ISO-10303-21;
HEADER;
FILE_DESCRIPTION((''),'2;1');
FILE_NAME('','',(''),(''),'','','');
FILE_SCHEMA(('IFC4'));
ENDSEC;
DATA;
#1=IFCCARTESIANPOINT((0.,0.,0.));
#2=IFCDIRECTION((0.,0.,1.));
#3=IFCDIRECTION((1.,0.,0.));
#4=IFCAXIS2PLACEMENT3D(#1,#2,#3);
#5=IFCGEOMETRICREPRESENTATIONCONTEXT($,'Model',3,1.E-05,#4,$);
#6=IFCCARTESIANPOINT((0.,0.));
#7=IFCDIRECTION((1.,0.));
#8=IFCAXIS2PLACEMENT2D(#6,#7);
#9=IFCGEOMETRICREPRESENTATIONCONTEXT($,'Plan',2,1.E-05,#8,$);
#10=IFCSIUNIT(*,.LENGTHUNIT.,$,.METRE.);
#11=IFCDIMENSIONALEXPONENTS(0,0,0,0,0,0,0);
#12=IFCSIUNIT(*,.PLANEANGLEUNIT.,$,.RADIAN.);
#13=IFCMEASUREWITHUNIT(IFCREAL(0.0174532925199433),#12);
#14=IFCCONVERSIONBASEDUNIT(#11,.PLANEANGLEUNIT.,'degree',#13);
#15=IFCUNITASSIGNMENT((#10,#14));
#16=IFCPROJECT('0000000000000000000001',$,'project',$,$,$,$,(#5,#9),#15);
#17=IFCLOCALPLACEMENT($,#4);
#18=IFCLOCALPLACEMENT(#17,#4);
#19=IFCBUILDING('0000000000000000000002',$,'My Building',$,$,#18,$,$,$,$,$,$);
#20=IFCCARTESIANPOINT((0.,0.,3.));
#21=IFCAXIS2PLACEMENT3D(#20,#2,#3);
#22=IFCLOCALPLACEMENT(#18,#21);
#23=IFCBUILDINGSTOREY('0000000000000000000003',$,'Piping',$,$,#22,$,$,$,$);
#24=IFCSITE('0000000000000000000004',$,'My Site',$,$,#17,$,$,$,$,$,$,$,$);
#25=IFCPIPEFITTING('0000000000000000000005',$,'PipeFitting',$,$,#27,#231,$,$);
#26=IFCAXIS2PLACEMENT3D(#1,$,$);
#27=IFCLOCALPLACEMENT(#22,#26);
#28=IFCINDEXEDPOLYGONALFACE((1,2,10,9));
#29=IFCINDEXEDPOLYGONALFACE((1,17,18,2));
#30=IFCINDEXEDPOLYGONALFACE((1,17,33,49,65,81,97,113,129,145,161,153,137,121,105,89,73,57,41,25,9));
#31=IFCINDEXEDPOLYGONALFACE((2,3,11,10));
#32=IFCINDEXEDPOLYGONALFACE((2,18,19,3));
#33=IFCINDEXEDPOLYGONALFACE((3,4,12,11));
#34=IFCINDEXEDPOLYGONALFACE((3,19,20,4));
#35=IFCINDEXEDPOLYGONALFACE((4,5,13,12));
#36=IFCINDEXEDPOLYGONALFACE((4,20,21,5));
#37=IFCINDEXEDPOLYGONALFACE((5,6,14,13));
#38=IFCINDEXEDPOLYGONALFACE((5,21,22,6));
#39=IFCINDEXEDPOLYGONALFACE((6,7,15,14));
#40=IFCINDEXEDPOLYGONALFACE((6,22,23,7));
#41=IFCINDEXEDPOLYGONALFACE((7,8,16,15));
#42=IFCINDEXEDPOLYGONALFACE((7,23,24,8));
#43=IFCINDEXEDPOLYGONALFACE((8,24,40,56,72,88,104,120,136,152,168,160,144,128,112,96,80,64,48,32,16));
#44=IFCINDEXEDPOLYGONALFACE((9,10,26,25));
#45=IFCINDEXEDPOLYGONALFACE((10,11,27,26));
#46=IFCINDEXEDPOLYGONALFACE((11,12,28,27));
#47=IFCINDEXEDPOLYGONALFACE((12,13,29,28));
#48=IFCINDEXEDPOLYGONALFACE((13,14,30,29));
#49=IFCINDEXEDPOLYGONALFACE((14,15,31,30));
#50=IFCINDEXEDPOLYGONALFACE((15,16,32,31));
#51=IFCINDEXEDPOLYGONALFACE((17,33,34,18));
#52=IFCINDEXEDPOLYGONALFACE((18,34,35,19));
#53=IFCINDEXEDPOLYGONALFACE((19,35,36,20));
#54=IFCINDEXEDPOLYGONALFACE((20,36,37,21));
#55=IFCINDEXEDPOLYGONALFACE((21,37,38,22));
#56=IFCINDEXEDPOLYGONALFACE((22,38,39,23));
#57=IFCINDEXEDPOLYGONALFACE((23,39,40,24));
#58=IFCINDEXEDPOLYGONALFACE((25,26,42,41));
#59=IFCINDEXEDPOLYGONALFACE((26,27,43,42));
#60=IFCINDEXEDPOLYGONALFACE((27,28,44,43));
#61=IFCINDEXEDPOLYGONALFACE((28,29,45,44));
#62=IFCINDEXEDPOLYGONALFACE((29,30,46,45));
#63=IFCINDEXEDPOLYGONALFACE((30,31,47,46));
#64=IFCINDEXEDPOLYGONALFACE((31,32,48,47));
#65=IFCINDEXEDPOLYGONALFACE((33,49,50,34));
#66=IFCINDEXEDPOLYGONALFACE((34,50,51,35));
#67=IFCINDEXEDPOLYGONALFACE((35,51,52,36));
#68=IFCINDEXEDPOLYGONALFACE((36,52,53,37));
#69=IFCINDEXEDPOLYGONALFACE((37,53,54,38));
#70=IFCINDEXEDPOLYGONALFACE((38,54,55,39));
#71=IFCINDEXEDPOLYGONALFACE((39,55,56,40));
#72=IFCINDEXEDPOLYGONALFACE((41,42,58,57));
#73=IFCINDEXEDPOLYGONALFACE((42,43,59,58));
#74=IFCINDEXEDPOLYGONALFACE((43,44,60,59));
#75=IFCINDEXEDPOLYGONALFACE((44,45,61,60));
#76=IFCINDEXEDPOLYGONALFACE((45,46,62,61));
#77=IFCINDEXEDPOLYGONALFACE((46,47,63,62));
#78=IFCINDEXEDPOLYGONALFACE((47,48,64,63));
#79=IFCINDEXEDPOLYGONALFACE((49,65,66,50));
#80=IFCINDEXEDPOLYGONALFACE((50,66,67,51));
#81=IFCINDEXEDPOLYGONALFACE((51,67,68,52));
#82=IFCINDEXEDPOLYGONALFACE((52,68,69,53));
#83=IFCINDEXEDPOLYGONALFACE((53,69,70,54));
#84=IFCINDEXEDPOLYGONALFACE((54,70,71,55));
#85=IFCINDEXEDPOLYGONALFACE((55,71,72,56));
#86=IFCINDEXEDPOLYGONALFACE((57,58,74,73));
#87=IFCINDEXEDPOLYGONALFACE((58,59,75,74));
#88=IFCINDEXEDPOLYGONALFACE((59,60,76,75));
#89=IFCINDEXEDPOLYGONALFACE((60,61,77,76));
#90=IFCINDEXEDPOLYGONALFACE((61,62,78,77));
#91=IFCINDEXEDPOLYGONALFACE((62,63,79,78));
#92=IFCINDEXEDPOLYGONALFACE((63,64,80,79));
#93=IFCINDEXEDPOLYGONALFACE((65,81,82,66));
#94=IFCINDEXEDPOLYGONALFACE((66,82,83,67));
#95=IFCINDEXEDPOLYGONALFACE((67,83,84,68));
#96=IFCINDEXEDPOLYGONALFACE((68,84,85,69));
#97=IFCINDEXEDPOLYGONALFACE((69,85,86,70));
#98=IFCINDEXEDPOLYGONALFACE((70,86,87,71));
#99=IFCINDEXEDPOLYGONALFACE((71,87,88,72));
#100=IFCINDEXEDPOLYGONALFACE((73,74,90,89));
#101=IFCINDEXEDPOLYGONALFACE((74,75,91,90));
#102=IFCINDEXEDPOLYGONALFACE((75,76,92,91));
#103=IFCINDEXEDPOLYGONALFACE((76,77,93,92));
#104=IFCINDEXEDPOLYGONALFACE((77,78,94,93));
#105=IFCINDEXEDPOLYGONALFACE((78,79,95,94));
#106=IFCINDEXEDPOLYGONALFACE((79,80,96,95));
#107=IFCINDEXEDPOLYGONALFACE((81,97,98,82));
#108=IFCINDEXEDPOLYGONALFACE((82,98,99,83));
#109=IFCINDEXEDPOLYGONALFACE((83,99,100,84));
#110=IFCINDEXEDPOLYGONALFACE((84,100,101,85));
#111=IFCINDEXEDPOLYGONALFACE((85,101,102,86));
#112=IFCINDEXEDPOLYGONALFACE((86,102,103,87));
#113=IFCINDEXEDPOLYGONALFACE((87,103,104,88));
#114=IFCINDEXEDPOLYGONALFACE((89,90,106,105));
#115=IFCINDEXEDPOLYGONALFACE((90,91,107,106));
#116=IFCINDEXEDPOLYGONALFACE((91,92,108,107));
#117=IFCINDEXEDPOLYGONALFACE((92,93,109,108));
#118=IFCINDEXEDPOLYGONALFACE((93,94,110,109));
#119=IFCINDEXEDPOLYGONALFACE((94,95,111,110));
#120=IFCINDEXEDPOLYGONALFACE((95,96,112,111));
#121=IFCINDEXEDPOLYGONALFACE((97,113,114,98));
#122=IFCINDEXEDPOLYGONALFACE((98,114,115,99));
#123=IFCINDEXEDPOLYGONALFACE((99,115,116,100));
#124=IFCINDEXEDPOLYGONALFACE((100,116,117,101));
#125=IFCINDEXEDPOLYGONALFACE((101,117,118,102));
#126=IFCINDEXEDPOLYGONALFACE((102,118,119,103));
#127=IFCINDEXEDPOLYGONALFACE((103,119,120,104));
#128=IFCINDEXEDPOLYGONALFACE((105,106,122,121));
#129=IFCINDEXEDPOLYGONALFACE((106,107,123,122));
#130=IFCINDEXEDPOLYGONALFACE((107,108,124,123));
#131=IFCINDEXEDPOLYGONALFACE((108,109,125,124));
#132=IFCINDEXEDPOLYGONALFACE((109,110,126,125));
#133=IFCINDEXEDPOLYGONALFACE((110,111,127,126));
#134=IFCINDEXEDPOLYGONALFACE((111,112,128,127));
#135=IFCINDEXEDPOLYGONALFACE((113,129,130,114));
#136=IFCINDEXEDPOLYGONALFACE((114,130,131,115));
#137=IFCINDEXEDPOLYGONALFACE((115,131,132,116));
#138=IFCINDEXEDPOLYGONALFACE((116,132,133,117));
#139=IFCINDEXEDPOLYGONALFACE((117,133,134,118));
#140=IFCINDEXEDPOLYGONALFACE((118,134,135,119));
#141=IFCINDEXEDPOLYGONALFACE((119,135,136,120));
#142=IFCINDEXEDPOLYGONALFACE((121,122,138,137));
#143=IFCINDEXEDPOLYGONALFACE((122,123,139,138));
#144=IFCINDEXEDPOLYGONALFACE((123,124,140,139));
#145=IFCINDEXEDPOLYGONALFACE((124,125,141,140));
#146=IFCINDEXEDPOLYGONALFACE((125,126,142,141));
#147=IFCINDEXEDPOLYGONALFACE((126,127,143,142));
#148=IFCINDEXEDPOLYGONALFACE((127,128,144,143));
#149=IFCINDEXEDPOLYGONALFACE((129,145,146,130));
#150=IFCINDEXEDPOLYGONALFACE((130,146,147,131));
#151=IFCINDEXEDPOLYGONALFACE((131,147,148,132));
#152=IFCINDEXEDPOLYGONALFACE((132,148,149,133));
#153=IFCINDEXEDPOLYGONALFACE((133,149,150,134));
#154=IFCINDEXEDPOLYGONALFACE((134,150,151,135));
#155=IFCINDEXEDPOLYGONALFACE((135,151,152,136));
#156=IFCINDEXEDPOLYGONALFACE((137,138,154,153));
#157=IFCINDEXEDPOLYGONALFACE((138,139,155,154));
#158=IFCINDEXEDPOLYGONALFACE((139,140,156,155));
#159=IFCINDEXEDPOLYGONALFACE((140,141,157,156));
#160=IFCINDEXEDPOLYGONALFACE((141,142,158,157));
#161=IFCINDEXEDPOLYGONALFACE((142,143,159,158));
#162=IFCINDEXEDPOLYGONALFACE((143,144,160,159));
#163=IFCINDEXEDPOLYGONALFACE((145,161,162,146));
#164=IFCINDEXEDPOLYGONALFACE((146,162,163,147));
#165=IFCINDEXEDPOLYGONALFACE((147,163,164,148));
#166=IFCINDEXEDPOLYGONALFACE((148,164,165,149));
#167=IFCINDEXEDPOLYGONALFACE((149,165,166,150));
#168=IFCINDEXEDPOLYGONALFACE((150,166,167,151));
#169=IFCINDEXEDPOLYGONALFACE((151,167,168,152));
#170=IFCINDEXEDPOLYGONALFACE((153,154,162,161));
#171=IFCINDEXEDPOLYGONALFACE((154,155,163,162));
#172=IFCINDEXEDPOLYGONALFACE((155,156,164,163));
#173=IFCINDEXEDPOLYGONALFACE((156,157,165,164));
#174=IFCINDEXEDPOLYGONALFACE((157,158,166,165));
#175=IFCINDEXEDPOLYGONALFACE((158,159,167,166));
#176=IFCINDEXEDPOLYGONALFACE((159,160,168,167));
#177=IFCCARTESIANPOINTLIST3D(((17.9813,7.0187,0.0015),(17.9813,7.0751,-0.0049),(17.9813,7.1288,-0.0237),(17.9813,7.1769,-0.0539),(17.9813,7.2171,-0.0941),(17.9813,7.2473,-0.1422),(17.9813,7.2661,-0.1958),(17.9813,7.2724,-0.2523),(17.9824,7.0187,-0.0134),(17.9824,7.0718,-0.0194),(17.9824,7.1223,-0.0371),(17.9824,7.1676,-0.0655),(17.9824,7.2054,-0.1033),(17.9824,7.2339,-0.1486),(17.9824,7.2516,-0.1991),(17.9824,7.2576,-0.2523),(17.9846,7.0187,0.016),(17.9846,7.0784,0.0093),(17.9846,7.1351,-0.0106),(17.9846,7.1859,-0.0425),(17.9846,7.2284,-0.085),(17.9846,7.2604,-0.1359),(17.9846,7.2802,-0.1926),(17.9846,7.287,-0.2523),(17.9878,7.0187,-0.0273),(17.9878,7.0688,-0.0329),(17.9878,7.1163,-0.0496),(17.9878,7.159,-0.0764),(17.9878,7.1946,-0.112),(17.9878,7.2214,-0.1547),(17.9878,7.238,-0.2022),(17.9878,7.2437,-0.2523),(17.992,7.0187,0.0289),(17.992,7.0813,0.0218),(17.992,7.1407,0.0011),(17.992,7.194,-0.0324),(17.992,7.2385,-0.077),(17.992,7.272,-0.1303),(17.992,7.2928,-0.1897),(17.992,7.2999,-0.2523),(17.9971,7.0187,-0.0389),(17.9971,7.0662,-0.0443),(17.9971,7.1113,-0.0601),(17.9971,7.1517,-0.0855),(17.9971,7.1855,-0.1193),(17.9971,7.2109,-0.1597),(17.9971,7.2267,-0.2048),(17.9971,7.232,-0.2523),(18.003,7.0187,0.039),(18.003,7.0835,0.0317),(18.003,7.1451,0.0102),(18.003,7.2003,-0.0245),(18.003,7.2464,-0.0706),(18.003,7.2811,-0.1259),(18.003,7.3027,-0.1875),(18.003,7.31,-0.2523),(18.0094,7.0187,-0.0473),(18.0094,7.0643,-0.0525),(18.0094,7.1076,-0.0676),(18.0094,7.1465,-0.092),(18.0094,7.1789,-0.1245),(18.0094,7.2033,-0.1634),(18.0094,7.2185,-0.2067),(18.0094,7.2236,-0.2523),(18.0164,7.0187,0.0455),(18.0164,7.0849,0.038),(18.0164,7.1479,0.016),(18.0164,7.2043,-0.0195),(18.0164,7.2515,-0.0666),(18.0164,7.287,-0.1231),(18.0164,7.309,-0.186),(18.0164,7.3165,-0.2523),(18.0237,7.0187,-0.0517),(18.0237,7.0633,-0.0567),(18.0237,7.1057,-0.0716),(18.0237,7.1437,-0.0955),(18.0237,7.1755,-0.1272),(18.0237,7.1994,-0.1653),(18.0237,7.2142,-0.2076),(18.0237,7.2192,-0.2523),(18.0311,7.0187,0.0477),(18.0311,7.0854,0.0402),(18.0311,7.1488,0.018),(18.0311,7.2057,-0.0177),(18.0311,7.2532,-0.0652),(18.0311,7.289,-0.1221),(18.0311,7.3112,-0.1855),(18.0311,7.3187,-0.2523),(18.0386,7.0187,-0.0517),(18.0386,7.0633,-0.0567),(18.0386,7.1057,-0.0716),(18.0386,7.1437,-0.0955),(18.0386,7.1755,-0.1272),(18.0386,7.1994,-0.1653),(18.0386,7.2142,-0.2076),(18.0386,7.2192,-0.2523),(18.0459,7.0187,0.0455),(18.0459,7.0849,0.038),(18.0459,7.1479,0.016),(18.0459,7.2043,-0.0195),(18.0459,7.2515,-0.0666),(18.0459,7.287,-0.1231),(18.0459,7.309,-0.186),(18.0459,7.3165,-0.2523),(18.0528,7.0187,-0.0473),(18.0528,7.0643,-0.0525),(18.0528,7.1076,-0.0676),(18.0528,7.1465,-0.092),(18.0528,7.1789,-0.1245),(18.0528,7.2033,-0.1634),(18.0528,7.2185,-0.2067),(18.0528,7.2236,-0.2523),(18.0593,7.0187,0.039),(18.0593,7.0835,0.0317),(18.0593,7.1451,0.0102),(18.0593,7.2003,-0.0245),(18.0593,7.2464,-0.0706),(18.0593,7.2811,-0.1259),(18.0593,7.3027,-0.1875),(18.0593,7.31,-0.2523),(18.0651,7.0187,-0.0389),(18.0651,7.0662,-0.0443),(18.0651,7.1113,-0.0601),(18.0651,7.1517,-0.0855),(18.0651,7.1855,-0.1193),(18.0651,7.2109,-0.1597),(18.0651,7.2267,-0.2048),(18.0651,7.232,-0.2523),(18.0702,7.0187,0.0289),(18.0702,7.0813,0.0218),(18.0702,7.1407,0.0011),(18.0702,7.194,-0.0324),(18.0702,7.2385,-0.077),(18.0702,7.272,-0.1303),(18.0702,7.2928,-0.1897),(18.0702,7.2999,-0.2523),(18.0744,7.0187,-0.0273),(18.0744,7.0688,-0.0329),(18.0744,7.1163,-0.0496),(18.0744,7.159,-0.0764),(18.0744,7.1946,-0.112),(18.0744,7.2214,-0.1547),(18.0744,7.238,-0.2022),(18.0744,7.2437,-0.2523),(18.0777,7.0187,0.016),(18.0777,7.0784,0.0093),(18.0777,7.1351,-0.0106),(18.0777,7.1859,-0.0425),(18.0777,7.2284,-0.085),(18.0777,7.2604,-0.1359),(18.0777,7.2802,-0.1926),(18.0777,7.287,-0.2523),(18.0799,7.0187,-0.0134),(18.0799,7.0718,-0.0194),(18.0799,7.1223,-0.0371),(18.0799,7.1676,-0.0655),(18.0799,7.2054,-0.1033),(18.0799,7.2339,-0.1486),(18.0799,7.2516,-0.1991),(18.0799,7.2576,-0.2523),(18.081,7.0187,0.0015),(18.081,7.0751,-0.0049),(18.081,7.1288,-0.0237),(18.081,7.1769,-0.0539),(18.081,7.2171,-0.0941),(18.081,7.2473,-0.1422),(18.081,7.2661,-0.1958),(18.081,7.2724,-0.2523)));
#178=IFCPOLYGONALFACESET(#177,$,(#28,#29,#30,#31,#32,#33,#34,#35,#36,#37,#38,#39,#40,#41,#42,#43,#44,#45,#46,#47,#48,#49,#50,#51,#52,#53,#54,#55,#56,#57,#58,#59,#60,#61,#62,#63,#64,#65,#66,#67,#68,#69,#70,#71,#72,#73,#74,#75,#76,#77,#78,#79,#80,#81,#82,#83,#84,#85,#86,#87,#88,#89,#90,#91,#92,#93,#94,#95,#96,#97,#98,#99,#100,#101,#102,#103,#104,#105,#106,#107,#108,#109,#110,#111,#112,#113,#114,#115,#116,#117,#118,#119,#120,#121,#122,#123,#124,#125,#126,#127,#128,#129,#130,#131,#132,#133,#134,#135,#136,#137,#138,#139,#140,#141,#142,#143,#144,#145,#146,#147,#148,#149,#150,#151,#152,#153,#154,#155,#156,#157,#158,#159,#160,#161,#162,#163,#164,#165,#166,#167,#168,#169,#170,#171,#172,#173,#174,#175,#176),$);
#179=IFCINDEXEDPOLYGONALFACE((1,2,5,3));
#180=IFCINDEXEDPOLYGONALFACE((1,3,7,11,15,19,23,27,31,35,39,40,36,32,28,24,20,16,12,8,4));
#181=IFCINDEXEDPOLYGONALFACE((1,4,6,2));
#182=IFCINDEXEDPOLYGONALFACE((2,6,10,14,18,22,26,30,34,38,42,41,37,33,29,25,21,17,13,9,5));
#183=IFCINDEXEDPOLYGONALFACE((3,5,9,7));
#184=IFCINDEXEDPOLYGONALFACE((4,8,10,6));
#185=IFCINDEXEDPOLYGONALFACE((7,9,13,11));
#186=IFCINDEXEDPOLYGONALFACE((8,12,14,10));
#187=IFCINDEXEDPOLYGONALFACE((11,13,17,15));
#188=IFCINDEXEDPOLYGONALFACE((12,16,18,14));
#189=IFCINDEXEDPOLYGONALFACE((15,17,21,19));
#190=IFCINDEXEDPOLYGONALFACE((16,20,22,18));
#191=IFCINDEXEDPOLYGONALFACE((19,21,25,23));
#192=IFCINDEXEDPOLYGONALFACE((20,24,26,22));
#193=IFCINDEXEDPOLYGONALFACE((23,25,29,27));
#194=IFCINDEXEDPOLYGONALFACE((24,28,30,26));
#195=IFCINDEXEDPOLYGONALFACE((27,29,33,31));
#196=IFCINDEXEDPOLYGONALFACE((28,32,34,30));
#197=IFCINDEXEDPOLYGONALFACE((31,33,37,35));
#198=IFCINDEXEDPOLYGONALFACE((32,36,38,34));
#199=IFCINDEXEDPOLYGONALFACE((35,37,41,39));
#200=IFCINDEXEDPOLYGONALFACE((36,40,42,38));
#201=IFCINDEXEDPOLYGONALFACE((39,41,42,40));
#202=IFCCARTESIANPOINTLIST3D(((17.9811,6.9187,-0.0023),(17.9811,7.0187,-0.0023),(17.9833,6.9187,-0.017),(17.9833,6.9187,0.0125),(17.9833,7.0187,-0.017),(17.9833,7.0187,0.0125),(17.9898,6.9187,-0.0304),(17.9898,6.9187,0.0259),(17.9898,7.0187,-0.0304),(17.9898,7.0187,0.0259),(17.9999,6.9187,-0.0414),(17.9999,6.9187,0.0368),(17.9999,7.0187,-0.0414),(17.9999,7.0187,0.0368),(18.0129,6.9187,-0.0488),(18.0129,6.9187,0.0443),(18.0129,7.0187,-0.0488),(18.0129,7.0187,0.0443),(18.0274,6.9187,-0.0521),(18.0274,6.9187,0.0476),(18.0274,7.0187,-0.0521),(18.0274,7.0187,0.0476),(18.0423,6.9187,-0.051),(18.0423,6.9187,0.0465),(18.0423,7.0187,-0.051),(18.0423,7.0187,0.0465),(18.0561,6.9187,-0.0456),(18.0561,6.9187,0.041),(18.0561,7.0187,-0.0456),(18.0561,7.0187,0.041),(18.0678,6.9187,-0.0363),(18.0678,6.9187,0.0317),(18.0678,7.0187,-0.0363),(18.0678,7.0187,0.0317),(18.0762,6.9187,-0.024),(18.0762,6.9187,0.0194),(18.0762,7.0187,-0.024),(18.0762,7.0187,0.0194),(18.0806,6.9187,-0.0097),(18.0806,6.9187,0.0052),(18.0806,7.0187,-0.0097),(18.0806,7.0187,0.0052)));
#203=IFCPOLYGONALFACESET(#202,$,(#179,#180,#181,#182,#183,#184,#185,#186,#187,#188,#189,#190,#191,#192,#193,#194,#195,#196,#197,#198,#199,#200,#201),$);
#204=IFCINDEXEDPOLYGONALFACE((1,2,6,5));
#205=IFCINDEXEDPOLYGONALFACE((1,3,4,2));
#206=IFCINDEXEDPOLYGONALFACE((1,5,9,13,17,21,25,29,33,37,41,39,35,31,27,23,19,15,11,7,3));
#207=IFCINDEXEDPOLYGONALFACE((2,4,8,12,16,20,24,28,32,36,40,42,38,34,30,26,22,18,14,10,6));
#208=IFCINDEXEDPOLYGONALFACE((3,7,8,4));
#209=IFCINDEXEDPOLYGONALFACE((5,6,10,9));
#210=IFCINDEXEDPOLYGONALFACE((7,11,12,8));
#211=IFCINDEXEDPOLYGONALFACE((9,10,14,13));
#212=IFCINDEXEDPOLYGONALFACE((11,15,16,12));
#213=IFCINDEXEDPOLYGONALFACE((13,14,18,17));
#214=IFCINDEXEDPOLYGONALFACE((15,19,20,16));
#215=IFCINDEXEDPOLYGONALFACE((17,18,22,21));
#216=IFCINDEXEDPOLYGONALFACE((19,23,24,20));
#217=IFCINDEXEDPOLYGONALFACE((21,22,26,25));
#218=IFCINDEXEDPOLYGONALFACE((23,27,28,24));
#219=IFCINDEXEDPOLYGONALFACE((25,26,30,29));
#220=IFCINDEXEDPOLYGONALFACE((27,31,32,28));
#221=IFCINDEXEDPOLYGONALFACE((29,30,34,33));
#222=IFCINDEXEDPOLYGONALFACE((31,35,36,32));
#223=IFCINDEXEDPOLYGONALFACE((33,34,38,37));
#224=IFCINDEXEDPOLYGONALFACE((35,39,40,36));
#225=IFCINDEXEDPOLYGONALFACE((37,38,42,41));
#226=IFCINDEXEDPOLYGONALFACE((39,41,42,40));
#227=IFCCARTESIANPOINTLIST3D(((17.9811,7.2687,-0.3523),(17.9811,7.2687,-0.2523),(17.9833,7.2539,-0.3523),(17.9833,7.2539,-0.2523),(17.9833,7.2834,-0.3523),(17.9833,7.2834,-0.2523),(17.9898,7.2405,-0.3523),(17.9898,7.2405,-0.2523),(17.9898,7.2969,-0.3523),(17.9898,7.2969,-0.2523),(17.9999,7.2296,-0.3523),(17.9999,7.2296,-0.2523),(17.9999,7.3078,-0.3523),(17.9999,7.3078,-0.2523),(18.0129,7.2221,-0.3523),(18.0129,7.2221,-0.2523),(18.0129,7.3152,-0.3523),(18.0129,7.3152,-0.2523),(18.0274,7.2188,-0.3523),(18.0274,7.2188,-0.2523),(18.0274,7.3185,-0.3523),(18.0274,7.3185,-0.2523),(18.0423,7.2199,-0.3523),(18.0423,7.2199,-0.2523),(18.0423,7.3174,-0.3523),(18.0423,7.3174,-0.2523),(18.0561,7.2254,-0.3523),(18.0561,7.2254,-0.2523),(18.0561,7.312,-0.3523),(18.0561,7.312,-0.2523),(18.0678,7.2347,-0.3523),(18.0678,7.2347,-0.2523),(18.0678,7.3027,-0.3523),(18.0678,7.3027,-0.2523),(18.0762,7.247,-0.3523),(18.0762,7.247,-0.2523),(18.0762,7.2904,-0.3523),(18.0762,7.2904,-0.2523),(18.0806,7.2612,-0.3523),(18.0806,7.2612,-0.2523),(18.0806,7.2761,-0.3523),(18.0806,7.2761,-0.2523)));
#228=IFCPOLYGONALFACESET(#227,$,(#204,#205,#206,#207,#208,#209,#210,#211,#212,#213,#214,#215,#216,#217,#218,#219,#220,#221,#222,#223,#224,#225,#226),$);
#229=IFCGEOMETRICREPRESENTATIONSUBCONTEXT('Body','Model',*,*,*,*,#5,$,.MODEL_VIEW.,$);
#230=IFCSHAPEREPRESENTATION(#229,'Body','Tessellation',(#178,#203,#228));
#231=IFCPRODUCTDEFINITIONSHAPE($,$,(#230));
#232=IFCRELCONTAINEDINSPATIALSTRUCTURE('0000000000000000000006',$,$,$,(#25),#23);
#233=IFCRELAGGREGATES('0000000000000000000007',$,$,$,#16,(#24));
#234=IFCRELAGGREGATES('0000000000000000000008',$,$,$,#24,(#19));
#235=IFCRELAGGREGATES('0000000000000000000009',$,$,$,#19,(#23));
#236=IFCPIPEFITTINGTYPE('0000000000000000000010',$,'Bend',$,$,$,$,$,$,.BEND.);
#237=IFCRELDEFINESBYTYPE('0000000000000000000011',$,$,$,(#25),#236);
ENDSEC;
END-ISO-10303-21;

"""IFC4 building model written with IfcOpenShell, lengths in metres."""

from ifc_helpers import new_model, entity, si_unit, converted_unit, frame, origin_with_axes, origin_2d_with_axis, place, context, subcontext, project, spatial, circle, extrude, source, transform, mapped, type_object, type_shapes, element, save


model = new_model("IFC4")

# Units and contexts
model_context = context("Model", 3, precision=1e-05, world=origin_with_axes())
plan_context = context("Plan", 2, precision=1e-05, world=origin_2d_with_axis())
body_context = subcontext(model_context, "Body", "Model", "MODEL_VIEW")
ifc_project = project(units=[si_unit("LENGTHUNIT", "METRE"), converted_unit("PLANEANGLEUNIT", "degree", entity("IfcReal", 0.0174532925199433), si_unit("PLANEANGLEUNIT", "RADIAN"), dimensions=[0, 0, 0, 0, 0, 0, 0])], contexts=[model_context, plan_context])

# Site, building, storey
site_placement = place(None, origin_with_axes())
site = spatial("IfcSite", under=ifc_project, at=site_placement, Name="My Site")
building_placement = place(site_placement, origin_with_axes())
building = spatial("IfcBuilding", under=site, at=building_placement, Name="My Building")
storey_placement = place(building_placement, frame((0.0, 0.0, 3.0), z_axis=(0.0, 0.0, 1.0), x_axis=(1.0, 0.0, 0.0)))
storey = spatial("IfcBuildingStorey", under=building, at=storey_placement, Name="Piping")

# Pipe fitting
pipe_fitting_type_1 = type_object("IfcPipeFittingType", Name="Bend", PredefinedType="BEND")
shared_shape = source(origin_with_axes(), body_context, "Body", "SolidModel", [
    entity("IfcSweptDiskSolid", entity("IfcIndexedPolyCurve", entity("IfcCartesianPointList3D", [[0.0, 0.0, -0.1], [0.0, 0.0732, -0.2768], [0.0, 0.25, -0.35]]), [entity("IfcArcIndex", [1, 2, 3])]), 0.05),
    extrude(circle(Radius=0.05), origin_with_axes(), (0.0, 0.0, -1.0), 0.1),
    extrude(circle(Radius=0.05), frame((0.0, 0.25, -0.35), z_axis=(0.0, 1.0, 0.0), x_axis=(1.0, 0.0, 0.0)), (0.0, 0.0, 1.0), 0.1),
])
type_shapes(pipe_fitting_type_1, [shared_shape])
for number, where, z_axis, x_axis, name in (
    (1, (18.0311, 6.9187, -0.0023), (0.0, -1.0, 0.0), (-1.0, 0.0, 0.0), "PipeFitting"),
):
    element("IfcPipeFitting", number, at=place(storey_placement, frame(where, z_axis=z_axis, x_axis=x_axis)), inside=storey, type_object=pipe_fitting_type_1, Name=name, context=body_context, shape_type="MappedRepresentation", body=[
        mapped(shared_shape, transform((0.0, 0.0, 0.0), x_axis=(1.0, 0.0, 0.0), y_axis=(0.0, 1.0, 0.0), z_axis=(0.0, 0.0, 1.0), scale=1.0)),
    ])

save(model, "model.ifc")
